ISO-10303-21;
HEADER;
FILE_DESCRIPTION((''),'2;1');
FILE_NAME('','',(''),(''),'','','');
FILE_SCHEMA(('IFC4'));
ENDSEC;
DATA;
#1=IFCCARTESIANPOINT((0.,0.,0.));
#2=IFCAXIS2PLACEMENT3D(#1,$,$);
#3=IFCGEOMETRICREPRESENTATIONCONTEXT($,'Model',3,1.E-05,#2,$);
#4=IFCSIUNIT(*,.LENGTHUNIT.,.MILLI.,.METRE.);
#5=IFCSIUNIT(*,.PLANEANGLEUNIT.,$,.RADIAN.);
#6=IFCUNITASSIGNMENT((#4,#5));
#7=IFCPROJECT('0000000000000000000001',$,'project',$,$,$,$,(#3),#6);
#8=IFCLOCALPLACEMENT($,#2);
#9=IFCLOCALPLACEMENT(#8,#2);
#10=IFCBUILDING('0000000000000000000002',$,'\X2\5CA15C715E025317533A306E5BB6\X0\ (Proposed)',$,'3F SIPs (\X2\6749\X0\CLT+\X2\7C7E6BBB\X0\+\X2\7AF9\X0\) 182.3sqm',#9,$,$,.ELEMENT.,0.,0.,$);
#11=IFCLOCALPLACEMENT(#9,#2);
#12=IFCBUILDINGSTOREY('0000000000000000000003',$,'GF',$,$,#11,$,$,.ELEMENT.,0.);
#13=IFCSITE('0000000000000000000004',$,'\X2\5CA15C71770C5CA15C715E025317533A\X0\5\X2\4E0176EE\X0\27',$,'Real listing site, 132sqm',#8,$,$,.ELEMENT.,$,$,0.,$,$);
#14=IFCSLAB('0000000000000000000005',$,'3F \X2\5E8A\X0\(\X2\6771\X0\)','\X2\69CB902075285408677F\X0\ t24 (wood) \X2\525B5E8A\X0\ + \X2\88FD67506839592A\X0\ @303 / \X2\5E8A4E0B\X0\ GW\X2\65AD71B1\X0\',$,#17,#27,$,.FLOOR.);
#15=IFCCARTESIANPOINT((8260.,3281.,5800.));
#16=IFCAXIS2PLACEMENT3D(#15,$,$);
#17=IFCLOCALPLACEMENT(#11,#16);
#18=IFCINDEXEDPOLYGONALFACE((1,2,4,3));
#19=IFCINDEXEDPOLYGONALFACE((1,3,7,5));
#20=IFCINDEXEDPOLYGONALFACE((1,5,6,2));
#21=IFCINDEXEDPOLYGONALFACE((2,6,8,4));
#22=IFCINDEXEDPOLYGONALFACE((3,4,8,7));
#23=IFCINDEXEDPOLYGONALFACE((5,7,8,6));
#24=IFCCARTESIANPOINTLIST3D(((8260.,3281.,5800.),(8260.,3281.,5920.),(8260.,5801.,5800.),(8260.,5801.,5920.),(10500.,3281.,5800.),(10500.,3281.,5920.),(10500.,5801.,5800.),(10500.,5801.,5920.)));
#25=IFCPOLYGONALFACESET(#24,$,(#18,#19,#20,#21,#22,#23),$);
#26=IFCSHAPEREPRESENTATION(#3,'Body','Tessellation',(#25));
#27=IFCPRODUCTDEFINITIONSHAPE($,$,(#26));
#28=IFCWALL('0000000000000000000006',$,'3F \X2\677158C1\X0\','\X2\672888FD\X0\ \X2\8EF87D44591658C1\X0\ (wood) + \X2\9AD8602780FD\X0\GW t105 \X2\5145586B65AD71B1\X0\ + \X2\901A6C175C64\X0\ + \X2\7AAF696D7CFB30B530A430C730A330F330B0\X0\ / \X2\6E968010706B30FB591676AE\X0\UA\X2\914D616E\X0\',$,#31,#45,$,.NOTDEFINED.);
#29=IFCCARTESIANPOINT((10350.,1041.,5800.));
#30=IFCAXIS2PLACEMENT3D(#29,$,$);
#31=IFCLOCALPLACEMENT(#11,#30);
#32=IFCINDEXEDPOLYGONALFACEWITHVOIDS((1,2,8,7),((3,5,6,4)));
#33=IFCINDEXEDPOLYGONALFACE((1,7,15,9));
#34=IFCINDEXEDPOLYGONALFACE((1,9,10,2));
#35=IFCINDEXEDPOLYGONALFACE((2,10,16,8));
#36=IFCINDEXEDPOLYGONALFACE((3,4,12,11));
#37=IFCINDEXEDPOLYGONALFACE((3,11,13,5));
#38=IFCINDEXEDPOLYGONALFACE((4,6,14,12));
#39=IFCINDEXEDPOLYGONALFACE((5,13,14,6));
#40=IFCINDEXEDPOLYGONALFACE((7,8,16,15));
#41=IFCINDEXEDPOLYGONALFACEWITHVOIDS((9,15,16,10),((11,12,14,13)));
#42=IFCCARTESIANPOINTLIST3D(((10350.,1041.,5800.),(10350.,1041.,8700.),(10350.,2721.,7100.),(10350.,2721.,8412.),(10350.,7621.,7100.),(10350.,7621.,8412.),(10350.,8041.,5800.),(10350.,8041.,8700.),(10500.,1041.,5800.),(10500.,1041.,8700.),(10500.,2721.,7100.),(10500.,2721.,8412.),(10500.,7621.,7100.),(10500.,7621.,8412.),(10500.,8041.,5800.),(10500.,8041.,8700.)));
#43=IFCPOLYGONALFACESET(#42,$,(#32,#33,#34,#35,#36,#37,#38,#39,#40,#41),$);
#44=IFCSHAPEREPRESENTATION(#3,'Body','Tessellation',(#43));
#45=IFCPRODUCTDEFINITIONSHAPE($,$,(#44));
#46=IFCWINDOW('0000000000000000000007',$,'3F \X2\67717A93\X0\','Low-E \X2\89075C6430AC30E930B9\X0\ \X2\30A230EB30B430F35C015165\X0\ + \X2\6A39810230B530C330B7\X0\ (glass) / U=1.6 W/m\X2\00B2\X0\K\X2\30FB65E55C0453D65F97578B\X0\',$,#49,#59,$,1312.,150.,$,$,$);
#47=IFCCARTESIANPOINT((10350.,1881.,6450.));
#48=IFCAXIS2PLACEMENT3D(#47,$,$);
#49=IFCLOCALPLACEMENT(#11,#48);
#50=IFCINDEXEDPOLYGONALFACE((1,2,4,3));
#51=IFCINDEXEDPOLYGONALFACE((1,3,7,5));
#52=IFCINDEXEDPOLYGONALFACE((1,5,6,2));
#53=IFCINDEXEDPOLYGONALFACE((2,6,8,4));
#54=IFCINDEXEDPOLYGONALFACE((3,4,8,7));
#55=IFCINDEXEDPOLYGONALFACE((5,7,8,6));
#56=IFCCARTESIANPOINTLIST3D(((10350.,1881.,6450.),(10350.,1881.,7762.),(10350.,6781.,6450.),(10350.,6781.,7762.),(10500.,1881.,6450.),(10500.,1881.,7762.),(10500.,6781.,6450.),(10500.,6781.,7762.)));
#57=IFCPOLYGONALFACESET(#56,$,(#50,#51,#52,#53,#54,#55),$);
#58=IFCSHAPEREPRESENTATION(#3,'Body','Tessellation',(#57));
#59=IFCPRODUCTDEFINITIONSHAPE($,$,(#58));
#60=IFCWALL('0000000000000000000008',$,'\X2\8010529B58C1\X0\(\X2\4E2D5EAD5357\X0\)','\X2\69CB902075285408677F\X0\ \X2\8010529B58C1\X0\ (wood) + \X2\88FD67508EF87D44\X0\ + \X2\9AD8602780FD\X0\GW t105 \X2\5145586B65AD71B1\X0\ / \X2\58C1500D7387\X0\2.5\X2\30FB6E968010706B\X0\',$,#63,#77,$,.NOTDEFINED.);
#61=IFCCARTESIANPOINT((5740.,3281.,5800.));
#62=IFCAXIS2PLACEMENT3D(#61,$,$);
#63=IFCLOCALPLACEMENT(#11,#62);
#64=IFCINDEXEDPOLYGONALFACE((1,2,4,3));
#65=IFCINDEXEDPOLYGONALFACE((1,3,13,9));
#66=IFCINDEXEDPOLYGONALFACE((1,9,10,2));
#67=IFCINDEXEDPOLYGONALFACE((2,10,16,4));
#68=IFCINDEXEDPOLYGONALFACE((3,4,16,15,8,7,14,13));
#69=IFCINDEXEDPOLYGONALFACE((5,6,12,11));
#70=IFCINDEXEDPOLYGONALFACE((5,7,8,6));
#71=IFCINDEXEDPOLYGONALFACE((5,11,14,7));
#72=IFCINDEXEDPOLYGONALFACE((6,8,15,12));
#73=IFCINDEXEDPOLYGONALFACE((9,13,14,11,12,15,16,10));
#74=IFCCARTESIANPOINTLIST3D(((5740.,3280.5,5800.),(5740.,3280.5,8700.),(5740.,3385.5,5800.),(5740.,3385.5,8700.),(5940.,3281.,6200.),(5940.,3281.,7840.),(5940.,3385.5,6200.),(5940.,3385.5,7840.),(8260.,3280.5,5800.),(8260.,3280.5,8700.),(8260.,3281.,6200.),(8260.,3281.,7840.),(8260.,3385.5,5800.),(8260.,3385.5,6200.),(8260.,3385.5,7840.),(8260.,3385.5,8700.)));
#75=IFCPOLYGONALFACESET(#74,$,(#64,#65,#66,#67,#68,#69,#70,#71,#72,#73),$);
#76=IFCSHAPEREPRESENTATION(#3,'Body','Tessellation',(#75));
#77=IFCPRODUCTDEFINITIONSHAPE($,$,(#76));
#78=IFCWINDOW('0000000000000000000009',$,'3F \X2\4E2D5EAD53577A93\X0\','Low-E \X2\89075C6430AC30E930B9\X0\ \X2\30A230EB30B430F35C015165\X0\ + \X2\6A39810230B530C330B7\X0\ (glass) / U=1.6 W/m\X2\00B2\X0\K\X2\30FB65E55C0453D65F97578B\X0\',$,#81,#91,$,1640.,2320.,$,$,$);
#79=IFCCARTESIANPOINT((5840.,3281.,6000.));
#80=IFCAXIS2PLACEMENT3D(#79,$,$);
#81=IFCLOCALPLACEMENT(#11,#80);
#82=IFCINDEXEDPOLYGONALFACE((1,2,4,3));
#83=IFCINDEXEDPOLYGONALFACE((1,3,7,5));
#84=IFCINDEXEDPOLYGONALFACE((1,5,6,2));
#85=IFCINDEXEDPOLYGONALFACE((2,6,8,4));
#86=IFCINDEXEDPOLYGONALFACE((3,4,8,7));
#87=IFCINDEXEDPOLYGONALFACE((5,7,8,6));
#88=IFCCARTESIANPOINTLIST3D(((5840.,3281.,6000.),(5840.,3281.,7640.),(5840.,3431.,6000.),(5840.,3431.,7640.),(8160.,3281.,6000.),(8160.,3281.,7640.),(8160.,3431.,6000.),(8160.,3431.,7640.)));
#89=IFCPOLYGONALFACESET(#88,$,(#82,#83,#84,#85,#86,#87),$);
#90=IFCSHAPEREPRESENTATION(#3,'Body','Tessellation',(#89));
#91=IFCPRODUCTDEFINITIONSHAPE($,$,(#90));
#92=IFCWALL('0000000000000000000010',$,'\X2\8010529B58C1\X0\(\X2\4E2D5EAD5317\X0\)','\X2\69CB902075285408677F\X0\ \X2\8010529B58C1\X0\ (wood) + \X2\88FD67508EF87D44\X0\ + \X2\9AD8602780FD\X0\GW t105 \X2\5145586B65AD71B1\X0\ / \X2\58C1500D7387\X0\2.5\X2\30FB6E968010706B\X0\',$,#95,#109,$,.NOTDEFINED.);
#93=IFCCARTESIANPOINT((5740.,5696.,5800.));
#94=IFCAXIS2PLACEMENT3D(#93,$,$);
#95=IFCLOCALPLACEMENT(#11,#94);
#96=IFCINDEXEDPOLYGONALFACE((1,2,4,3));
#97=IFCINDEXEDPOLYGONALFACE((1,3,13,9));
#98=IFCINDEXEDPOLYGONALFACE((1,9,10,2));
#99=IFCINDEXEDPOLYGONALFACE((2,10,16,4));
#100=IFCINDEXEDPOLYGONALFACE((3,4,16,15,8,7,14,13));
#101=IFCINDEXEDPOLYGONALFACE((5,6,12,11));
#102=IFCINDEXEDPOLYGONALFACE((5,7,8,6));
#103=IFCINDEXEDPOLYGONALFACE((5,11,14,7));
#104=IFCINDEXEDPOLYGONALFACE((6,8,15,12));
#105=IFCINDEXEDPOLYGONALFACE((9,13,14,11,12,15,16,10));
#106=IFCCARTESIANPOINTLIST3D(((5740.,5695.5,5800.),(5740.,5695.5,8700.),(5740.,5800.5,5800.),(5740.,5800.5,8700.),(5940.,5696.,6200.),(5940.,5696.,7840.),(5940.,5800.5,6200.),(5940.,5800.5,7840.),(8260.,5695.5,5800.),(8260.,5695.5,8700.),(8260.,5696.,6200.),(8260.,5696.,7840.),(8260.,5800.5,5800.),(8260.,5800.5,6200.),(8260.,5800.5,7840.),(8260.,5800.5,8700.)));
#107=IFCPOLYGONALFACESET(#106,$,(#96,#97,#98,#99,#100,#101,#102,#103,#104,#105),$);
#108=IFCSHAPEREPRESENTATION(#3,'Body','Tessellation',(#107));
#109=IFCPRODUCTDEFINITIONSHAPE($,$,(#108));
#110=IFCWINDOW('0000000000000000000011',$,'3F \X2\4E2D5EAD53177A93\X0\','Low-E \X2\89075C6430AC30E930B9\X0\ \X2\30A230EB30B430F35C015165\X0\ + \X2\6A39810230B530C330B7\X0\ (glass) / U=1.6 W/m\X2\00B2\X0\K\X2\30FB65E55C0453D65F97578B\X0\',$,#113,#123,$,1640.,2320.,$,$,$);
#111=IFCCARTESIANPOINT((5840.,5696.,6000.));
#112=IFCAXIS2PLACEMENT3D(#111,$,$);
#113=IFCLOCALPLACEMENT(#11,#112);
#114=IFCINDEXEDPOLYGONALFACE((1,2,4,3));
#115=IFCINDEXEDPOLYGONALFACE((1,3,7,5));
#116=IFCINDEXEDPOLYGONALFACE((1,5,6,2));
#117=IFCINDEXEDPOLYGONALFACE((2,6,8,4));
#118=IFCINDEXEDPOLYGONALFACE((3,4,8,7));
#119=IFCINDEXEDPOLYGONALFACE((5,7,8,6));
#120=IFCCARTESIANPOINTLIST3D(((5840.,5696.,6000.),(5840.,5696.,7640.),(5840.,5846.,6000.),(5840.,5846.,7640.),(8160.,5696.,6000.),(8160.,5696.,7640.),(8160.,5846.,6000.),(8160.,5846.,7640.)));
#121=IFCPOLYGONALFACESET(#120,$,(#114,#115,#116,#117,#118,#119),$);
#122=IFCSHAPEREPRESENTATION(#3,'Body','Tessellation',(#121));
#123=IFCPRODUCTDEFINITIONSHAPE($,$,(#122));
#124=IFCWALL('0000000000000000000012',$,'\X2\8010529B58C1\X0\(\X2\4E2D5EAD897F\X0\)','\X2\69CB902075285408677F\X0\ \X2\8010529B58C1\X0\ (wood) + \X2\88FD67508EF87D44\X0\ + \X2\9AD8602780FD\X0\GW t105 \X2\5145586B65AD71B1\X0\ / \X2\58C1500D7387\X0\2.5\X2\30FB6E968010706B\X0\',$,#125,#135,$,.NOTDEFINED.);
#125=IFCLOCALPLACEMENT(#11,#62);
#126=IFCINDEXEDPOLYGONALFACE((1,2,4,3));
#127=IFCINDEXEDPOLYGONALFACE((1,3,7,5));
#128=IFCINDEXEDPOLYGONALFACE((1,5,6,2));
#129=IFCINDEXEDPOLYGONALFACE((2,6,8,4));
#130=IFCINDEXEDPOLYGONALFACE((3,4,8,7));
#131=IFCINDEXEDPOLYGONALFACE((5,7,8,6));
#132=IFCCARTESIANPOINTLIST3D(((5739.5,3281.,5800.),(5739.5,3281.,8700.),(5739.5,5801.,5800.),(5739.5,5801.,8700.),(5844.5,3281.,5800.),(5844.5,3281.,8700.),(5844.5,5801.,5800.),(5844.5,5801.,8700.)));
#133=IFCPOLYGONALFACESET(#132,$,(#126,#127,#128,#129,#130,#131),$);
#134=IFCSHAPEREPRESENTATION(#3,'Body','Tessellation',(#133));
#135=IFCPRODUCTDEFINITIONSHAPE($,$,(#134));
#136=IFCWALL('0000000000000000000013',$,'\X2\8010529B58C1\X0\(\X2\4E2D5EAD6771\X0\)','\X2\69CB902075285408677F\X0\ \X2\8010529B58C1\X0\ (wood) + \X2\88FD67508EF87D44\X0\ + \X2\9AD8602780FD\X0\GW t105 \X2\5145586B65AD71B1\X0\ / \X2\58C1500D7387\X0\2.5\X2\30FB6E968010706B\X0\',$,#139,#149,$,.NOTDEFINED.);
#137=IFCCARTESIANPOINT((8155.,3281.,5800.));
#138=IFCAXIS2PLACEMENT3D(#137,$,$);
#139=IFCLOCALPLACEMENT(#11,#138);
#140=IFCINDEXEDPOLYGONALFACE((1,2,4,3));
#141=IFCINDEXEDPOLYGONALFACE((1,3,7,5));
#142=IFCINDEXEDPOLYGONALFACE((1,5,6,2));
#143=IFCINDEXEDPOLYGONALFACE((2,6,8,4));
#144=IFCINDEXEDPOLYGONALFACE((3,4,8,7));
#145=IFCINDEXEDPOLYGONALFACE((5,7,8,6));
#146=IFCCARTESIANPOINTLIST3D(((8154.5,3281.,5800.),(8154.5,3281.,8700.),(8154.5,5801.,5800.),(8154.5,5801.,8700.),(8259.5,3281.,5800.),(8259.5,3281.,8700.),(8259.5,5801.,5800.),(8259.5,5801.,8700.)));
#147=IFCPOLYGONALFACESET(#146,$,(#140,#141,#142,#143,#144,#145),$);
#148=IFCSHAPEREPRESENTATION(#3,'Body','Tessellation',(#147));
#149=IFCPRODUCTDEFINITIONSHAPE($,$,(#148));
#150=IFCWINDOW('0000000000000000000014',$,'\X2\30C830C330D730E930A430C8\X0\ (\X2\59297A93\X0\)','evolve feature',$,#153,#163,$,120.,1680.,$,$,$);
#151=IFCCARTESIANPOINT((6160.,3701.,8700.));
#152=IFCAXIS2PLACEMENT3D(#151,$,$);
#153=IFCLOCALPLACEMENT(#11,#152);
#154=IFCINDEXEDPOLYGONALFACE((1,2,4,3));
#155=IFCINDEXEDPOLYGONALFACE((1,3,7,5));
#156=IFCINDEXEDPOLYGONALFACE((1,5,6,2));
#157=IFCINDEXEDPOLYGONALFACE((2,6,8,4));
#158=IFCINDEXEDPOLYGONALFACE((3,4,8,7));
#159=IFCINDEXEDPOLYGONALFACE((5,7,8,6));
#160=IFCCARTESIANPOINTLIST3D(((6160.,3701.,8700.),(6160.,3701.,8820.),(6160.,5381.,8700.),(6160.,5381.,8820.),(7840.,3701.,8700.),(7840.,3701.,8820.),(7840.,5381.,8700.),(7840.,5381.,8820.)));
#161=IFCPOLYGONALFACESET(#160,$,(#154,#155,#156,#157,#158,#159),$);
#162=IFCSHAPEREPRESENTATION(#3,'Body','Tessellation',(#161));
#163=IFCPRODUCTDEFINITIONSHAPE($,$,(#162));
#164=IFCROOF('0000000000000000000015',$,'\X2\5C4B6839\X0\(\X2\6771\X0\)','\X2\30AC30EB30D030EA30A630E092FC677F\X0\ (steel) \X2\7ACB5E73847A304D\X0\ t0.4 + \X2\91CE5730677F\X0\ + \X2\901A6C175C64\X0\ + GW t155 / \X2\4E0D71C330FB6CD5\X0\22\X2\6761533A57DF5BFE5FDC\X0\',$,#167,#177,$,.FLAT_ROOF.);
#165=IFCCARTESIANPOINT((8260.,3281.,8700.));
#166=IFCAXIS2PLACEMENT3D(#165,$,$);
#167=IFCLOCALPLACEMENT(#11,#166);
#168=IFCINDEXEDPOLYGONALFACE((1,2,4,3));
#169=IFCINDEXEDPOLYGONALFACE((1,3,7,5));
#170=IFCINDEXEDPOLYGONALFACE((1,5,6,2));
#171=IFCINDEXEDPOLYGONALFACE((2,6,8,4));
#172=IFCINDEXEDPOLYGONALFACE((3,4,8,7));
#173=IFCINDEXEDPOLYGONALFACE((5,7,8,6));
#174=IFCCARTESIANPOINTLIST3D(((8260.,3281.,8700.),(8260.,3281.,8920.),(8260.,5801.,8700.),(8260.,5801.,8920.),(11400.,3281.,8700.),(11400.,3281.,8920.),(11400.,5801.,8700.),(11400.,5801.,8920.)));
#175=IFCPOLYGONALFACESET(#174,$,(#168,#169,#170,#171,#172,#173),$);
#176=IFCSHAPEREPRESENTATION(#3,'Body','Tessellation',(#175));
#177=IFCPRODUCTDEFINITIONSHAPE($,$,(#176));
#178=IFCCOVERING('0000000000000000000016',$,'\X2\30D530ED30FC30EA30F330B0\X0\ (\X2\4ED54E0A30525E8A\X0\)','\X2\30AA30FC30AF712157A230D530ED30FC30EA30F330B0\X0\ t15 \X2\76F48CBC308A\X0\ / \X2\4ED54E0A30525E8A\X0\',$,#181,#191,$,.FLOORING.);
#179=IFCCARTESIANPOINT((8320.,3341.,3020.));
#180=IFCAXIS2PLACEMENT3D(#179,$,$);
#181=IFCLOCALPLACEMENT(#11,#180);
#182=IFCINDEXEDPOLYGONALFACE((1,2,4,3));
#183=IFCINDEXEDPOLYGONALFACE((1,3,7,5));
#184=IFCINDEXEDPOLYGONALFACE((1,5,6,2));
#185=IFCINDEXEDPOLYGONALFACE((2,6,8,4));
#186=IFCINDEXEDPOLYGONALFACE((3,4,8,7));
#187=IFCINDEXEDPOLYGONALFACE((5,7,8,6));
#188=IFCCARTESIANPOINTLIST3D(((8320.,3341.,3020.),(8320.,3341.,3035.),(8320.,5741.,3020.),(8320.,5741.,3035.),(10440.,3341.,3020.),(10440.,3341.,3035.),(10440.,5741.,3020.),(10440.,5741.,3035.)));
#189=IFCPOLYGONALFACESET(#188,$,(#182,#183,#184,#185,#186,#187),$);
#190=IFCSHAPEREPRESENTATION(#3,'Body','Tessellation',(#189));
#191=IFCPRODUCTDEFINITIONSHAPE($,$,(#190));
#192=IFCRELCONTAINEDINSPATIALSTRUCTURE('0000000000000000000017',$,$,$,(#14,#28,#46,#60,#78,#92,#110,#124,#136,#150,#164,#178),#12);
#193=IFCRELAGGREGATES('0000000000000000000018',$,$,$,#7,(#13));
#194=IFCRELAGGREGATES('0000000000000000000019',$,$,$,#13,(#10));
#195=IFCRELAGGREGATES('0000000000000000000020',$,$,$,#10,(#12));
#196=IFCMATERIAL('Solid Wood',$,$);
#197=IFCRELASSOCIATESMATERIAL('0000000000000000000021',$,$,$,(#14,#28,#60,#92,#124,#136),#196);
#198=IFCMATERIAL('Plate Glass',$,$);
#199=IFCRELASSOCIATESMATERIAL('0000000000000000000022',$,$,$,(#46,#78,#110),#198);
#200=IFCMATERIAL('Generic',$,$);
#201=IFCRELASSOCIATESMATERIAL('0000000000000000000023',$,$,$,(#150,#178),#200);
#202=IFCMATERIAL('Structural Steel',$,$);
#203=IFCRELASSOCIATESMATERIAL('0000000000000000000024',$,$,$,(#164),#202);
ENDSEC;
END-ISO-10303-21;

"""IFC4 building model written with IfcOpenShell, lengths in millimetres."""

from ifc_helpers import new_model, si_unit, frame, frame_2d, origin, place, context, project, spatial, rectangle, extrude, material, element, fill, save


model = new_model("IFC4")

# Units and contexts
model_context = context("Model", 3, precision=1e-05, world=origin())
ifc_project = project(units=[si_unit("LENGTHUNIT", "METRE", prefix="MILLI"), si_unit("PLANEANGLEUNIT", "RADIAN")], contexts=[model_context])

# Site, building, storey
site_placement = place(None, origin())
site = spatial("IfcSite", under=ifc_project, at=site_placement, Name="岡山県岡山市北区5丁目27", ObjectType="Real listing site, 132sqm", CompositionType="ELEMENT", RefElevation=0.0)
building_placement = place(site_placement, origin())
building = spatial("IfcBuilding", under=site, at=building_placement, Name="岡山市北区の家 (Proposed)", ObjectType="3F SIPs (杉CLT+籾殻+竹) 182.3sqm", CompositionType="ELEMENT", ElevationOfRefHeight=0.0, ElevationOfTerrain=0.0)
storey_placement = place(building_placement, origin())
storey = spatial("IfcBuildingStorey", under=building, at=storey_placement, Name="GF", CompositionType="ELEMENT", Elevation=0.0)

# Slab
ifc_material_1 = material(Name="Solid Wood")
slab_placement = place(storey_placement, frame((8260.0, 3281.0, 5800.0)))
element("IfcSlab", 1, at=slab_placement, inside=storey, material=ifc_material_1, Name="3F 床(東)", Description="構造用合板 t24 (wood) 剛床 + 製材根太 @303 / 床下 GW断熱", PredefinedType="FLOOR", context=model_context, shape_type="SweptSolid", body=[
    extrude(rectangle(XDim=2240.0, YDim=2520.0, at=frame_2d((1120.0, 1260.0))), frame((8260.0, 3281.0, 5800.0)), (0.0, 0.0, 1.0), 120.0),
])

# Walls, openings, windows
wall_1_placement = place(storey_placement, frame((10350.0, 1041.0, 5800.0)))
wall_1 = element("IfcWall", 2, at=wall_1_placement, inside=storey, material=ifc_material_1, Name="3F 東壁", Description="木製 軸組外壁 (wood) + 高性能GW t105 充填断熱 + 通気層 + 窯業系サイディング / 準耐火・外皮UA配慮", PredefinedType="NOTDEFINED", context=model_context, shape_type="SweptSolid", body=[
    extrude(rectangle(XDim=150.0, YDim=7000.0, at=frame_2d((75.0, 3500.0))), frame((10350.0, 1041.0, 5800.0)), (0.0, 0.0, 1.0), 2900.0),
])
opening_1_placement = place(storey_placement, frame((10350.0, 1881.0, 6450.0)))
opening_1 = element("IfcOpeningElement", 3, at=opening_1_placement, cuts=wall_1, PredefinedType="NOTDEFINED", context=model_context, shape_type="SweptSolid", body=[
    extrude(rectangle(XDim=150.0, YDim=4900.0, at=frame_2d((75.0, 2450.0))), frame((10350.0, 1881.0, 6450.0)), (0.0, 0.0, 1.0), 1312.0),
])
ifc_material_2 = material(Name="Plate Glass")
window_1_placement = place(storey_placement, frame((10350.0, 1881.0, 6450.0)))
window_1 = element("IfcWindow", 4, at=window_1_placement, inside=storey, material=ifc_material_2, Name="3F 東窓", Description="Low-E 複層ガラス アルゴン封入 + 樹脂サッシ (glass) / U=1.6 W/m²K・日射取得型", OverallHeight=1312.0, OverallWidth=150.0, context=model_context, shape_type="SweptSolid", body=[
    extrude(rectangle(XDim=150.0, YDim=4900.0, at=frame_2d((75.0, 2450.0))), frame((10350.0, 1881.0, 6450.0)), (0.0, 0.0, 1.0), 1312.0),
])
fill(opening_1, window_1)
wall_2_placement = place(storey_placement, frame((5740.0, 3281.0, 5800.0)))
wall_2 = element("IfcWall", 5, at=wall_2_placement, inside=storey, material=ifc_material_1, Name="耐力壁(中庭南)", Description="構造用合板 耐力壁 (wood) + 製材軸組 + 高性能GW t105 充填断熱 / 壁倍率2.5・準耐火", PredefinedType="NOTDEFINED", context=model_context, shape_type="SweptSolid", body=[
    extrude(rectangle(XDim=2520.0, YDim=105.0, at=frame_2d((1260.0, 52.0))), frame((5740.0, 3281.0, 5800.0)), (0.0, 0.0, 1.0), 2900.0),
])
opening_2_placement = place(storey_placement, frame((5840.0, 3281.0, 6000.0)))
opening_2 = element("IfcOpeningElement", 6, at=opening_2_placement, cuts=wall_2, PredefinedType="NOTDEFINED", context=model_context, shape_type="SweptSolid", body=[
    extrude(rectangle(XDim=2320.0, YDim=150.0, at=frame_2d((1160.0, 75.0))), frame((5840.0, 3281.0, 6000.0)), (0.0, 0.0, 1.0), 1640.0),
])
window_2_placement = place(storey_placement, frame((5840.0, 3281.0, 6000.0)))
window_2 = element("IfcWindow", 7, at=window_2_placement, inside=storey, material=ifc_material_2, Name="3F 中庭南窓", Description="Low-E 複層ガラス アルゴン封入 + 樹脂サッシ (glass) / U=1.6 W/m²K・日射取得型", OverallHeight=1640.0, OverallWidth=2320.0, context=model_context, shape_type="SweptSolid", body=[
    extrude(rectangle(XDim=2320.0, YDim=150.0, at=frame_2d((1160.0, 75.0))), frame((5840.0, 3281.0, 6000.0)), (0.0, 0.0, 1.0), 1640.0),
])
fill(opening_2, window_2)
wall_3_placement = place(storey_placement, frame((5740.0, 5696.0, 5800.0)))
wall_3 = element("IfcWall", 8, at=wall_3_placement, inside=storey, material=ifc_material_1, Name="耐力壁(中庭北)", Description="構造用合板 耐力壁 (wood) + 製材軸組 + 高性能GW t105 充填断熱 / 壁倍率2.5・準耐火", PredefinedType="NOTDEFINED", context=model_context, shape_type="SweptSolid", body=[
    extrude(rectangle(XDim=2520.0, YDim=105.0, at=frame_2d((1260.0, 52.0))), frame((5740.0, 5696.0, 5800.0)), (0.0, 0.0, 1.0), 2900.0),
])
opening_3_placement = place(storey_placement, frame((5840.0, 5696.0, 6000.0)))
opening_3 = element("IfcOpeningElement", 9, at=opening_3_placement, cuts=wall_3, PredefinedType="NOTDEFINED", context=model_context, shape_type="SweptSolid", body=[
    extrude(rectangle(XDim=2320.0, YDim=150.0, at=frame_2d((1160.0, 75.0))), frame((5840.0, 5696.0, 6000.0)), (0.0, 0.0, 1.0), 1640.0),
])
window_3_placement = place(storey_placement, frame((5840.0, 5696.0, 6000.0)))
window_3 = element("IfcWindow", 10, at=window_3_placement, inside=storey, material=ifc_material_2, Name="3F 中庭北窓", Description="Low-E 複層ガラス アルゴン封入 + 樹脂サッシ (glass) / U=1.6 W/m²K・日射取得型", OverallHeight=1640.0, OverallWidth=2320.0, context=model_context, shape_type="SweptSolid", body=[
    extrude(rectangle(XDim=2320.0, YDim=150.0, at=frame_2d((1160.0, 75.0))), frame((5840.0, 5696.0, 6000.0)), (0.0, 0.0, 1.0), 1640.0),
])
fill(opening_3, window_3)

# Walls
wall_4_placement = place(storey_placement, frame((5740.0, 3281.0, 5800.0)))
element("IfcWall", 11, at=wall_4_placement, inside=storey, material=ifc_material_1, Name="耐力壁(中庭西)", Description="構造用合板 耐力壁 (wood) + 製材軸組 + 高性能GW t105 充填断熱 / 壁倍率2.5・準耐火", PredefinedType="NOTDEFINED", context=model_context, shape_type="SweptSolid", body=[
    extrude(rectangle(XDim=105.0, YDim=2520.0, at=frame_2d((52.0, 1260.0))), frame((5740.0, 3281.0, 5800.0)), (0.0, 0.0, 1.0), 2900.0),
])
wall_5_placement = place(storey_placement, frame((8155.0, 3281.0, 5800.0)))
element("IfcWall", 12, at=wall_5_placement, inside=storey, material=ifc_material_1, Name="耐力壁(中庭東)", Description="構造用合板 耐力壁 (wood) + 製材軸組 + 高性能GW t105 充填断熱 / 壁倍率2.5・準耐火", PredefinedType="NOTDEFINED", context=model_context, shape_type="SweptSolid", body=[
    extrude(rectangle(XDim=105.0, YDim=2520.0, at=frame_2d((52.0, 1260.0))), frame((8155.0, 3281.0, 5800.0)), (0.0, 0.0, 1.0), 2900.0),
])

# Window
ifc_material_3 = material(Name="Generic")
window_4_placement = place(storey_placement, frame((6160.0, 3701.0, 8700.0)))
element("IfcWindow", 13, at=window_4_placement, inside=storey, material=ifc_material_3, Name="トップライト (天窓)", Description="evolve feature", OverallHeight=120.0, OverallWidth=1680.0, context=model_context, shape_type="SweptSolid", body=[
    extrude(rectangle(XDim=1680.0, YDim=1680.0, at=frame_2d((840.0, 840.0))), frame((6160.0, 3701.0, 8700.0)), (0.0, 0.0, 1.0), 120.0),
])

# Roof
ifc_material_4 = material(Name="Structural Steel")
for number, where, name in (
    (14, (8260.0, 3281.0, 8700.0), "屋根(東)"),
):
    element("IfcRoof", number, at=place(storey_placement, frame(where)), inside=storey, material=ifc_material_4, Name=name, Description="ガルバリウム鋼板 (steel) 立平葺き t0.4 + 野地板 + 通気層 + GW t155 / 不燃・法22条区域対応", PredefinedType="FLAT_ROOF", context=model_context, shape_type="SweptSolid", body=[
        extrude(rectangle(XDim=3140.0, YDim=2520.0, at=frame_2d((1570.0, 1260.0))), frame((8260.0, 3281.0, 8700.0)), (0.0, 0.0, 1.0), 220.0),
    ])

# Covering
covering_1_placement = place(storey_placement, frame((8320.0, 3341.0, 3020.0)))
element("IfcCovering", 15, at=covering_1_placement, inside=storey, material=ifc_material_3, Name="フローリング (仕上げ床)", Description="オーク無垢フローリング t15 直貼り / 仕上げ床", PredefinedType="FLOORING", context=model_context, shape_type="SweptSolid", body=[
    extrude(rectangle(XDim=2120.0, YDim=2400.0, at=frame_2d((1060.0, 1200.0))), frame((8320.0, 3341.0, 3020.0)), (0.0, 0.0, 1.0), 15.0),
])

save(model, "model.ifc")
